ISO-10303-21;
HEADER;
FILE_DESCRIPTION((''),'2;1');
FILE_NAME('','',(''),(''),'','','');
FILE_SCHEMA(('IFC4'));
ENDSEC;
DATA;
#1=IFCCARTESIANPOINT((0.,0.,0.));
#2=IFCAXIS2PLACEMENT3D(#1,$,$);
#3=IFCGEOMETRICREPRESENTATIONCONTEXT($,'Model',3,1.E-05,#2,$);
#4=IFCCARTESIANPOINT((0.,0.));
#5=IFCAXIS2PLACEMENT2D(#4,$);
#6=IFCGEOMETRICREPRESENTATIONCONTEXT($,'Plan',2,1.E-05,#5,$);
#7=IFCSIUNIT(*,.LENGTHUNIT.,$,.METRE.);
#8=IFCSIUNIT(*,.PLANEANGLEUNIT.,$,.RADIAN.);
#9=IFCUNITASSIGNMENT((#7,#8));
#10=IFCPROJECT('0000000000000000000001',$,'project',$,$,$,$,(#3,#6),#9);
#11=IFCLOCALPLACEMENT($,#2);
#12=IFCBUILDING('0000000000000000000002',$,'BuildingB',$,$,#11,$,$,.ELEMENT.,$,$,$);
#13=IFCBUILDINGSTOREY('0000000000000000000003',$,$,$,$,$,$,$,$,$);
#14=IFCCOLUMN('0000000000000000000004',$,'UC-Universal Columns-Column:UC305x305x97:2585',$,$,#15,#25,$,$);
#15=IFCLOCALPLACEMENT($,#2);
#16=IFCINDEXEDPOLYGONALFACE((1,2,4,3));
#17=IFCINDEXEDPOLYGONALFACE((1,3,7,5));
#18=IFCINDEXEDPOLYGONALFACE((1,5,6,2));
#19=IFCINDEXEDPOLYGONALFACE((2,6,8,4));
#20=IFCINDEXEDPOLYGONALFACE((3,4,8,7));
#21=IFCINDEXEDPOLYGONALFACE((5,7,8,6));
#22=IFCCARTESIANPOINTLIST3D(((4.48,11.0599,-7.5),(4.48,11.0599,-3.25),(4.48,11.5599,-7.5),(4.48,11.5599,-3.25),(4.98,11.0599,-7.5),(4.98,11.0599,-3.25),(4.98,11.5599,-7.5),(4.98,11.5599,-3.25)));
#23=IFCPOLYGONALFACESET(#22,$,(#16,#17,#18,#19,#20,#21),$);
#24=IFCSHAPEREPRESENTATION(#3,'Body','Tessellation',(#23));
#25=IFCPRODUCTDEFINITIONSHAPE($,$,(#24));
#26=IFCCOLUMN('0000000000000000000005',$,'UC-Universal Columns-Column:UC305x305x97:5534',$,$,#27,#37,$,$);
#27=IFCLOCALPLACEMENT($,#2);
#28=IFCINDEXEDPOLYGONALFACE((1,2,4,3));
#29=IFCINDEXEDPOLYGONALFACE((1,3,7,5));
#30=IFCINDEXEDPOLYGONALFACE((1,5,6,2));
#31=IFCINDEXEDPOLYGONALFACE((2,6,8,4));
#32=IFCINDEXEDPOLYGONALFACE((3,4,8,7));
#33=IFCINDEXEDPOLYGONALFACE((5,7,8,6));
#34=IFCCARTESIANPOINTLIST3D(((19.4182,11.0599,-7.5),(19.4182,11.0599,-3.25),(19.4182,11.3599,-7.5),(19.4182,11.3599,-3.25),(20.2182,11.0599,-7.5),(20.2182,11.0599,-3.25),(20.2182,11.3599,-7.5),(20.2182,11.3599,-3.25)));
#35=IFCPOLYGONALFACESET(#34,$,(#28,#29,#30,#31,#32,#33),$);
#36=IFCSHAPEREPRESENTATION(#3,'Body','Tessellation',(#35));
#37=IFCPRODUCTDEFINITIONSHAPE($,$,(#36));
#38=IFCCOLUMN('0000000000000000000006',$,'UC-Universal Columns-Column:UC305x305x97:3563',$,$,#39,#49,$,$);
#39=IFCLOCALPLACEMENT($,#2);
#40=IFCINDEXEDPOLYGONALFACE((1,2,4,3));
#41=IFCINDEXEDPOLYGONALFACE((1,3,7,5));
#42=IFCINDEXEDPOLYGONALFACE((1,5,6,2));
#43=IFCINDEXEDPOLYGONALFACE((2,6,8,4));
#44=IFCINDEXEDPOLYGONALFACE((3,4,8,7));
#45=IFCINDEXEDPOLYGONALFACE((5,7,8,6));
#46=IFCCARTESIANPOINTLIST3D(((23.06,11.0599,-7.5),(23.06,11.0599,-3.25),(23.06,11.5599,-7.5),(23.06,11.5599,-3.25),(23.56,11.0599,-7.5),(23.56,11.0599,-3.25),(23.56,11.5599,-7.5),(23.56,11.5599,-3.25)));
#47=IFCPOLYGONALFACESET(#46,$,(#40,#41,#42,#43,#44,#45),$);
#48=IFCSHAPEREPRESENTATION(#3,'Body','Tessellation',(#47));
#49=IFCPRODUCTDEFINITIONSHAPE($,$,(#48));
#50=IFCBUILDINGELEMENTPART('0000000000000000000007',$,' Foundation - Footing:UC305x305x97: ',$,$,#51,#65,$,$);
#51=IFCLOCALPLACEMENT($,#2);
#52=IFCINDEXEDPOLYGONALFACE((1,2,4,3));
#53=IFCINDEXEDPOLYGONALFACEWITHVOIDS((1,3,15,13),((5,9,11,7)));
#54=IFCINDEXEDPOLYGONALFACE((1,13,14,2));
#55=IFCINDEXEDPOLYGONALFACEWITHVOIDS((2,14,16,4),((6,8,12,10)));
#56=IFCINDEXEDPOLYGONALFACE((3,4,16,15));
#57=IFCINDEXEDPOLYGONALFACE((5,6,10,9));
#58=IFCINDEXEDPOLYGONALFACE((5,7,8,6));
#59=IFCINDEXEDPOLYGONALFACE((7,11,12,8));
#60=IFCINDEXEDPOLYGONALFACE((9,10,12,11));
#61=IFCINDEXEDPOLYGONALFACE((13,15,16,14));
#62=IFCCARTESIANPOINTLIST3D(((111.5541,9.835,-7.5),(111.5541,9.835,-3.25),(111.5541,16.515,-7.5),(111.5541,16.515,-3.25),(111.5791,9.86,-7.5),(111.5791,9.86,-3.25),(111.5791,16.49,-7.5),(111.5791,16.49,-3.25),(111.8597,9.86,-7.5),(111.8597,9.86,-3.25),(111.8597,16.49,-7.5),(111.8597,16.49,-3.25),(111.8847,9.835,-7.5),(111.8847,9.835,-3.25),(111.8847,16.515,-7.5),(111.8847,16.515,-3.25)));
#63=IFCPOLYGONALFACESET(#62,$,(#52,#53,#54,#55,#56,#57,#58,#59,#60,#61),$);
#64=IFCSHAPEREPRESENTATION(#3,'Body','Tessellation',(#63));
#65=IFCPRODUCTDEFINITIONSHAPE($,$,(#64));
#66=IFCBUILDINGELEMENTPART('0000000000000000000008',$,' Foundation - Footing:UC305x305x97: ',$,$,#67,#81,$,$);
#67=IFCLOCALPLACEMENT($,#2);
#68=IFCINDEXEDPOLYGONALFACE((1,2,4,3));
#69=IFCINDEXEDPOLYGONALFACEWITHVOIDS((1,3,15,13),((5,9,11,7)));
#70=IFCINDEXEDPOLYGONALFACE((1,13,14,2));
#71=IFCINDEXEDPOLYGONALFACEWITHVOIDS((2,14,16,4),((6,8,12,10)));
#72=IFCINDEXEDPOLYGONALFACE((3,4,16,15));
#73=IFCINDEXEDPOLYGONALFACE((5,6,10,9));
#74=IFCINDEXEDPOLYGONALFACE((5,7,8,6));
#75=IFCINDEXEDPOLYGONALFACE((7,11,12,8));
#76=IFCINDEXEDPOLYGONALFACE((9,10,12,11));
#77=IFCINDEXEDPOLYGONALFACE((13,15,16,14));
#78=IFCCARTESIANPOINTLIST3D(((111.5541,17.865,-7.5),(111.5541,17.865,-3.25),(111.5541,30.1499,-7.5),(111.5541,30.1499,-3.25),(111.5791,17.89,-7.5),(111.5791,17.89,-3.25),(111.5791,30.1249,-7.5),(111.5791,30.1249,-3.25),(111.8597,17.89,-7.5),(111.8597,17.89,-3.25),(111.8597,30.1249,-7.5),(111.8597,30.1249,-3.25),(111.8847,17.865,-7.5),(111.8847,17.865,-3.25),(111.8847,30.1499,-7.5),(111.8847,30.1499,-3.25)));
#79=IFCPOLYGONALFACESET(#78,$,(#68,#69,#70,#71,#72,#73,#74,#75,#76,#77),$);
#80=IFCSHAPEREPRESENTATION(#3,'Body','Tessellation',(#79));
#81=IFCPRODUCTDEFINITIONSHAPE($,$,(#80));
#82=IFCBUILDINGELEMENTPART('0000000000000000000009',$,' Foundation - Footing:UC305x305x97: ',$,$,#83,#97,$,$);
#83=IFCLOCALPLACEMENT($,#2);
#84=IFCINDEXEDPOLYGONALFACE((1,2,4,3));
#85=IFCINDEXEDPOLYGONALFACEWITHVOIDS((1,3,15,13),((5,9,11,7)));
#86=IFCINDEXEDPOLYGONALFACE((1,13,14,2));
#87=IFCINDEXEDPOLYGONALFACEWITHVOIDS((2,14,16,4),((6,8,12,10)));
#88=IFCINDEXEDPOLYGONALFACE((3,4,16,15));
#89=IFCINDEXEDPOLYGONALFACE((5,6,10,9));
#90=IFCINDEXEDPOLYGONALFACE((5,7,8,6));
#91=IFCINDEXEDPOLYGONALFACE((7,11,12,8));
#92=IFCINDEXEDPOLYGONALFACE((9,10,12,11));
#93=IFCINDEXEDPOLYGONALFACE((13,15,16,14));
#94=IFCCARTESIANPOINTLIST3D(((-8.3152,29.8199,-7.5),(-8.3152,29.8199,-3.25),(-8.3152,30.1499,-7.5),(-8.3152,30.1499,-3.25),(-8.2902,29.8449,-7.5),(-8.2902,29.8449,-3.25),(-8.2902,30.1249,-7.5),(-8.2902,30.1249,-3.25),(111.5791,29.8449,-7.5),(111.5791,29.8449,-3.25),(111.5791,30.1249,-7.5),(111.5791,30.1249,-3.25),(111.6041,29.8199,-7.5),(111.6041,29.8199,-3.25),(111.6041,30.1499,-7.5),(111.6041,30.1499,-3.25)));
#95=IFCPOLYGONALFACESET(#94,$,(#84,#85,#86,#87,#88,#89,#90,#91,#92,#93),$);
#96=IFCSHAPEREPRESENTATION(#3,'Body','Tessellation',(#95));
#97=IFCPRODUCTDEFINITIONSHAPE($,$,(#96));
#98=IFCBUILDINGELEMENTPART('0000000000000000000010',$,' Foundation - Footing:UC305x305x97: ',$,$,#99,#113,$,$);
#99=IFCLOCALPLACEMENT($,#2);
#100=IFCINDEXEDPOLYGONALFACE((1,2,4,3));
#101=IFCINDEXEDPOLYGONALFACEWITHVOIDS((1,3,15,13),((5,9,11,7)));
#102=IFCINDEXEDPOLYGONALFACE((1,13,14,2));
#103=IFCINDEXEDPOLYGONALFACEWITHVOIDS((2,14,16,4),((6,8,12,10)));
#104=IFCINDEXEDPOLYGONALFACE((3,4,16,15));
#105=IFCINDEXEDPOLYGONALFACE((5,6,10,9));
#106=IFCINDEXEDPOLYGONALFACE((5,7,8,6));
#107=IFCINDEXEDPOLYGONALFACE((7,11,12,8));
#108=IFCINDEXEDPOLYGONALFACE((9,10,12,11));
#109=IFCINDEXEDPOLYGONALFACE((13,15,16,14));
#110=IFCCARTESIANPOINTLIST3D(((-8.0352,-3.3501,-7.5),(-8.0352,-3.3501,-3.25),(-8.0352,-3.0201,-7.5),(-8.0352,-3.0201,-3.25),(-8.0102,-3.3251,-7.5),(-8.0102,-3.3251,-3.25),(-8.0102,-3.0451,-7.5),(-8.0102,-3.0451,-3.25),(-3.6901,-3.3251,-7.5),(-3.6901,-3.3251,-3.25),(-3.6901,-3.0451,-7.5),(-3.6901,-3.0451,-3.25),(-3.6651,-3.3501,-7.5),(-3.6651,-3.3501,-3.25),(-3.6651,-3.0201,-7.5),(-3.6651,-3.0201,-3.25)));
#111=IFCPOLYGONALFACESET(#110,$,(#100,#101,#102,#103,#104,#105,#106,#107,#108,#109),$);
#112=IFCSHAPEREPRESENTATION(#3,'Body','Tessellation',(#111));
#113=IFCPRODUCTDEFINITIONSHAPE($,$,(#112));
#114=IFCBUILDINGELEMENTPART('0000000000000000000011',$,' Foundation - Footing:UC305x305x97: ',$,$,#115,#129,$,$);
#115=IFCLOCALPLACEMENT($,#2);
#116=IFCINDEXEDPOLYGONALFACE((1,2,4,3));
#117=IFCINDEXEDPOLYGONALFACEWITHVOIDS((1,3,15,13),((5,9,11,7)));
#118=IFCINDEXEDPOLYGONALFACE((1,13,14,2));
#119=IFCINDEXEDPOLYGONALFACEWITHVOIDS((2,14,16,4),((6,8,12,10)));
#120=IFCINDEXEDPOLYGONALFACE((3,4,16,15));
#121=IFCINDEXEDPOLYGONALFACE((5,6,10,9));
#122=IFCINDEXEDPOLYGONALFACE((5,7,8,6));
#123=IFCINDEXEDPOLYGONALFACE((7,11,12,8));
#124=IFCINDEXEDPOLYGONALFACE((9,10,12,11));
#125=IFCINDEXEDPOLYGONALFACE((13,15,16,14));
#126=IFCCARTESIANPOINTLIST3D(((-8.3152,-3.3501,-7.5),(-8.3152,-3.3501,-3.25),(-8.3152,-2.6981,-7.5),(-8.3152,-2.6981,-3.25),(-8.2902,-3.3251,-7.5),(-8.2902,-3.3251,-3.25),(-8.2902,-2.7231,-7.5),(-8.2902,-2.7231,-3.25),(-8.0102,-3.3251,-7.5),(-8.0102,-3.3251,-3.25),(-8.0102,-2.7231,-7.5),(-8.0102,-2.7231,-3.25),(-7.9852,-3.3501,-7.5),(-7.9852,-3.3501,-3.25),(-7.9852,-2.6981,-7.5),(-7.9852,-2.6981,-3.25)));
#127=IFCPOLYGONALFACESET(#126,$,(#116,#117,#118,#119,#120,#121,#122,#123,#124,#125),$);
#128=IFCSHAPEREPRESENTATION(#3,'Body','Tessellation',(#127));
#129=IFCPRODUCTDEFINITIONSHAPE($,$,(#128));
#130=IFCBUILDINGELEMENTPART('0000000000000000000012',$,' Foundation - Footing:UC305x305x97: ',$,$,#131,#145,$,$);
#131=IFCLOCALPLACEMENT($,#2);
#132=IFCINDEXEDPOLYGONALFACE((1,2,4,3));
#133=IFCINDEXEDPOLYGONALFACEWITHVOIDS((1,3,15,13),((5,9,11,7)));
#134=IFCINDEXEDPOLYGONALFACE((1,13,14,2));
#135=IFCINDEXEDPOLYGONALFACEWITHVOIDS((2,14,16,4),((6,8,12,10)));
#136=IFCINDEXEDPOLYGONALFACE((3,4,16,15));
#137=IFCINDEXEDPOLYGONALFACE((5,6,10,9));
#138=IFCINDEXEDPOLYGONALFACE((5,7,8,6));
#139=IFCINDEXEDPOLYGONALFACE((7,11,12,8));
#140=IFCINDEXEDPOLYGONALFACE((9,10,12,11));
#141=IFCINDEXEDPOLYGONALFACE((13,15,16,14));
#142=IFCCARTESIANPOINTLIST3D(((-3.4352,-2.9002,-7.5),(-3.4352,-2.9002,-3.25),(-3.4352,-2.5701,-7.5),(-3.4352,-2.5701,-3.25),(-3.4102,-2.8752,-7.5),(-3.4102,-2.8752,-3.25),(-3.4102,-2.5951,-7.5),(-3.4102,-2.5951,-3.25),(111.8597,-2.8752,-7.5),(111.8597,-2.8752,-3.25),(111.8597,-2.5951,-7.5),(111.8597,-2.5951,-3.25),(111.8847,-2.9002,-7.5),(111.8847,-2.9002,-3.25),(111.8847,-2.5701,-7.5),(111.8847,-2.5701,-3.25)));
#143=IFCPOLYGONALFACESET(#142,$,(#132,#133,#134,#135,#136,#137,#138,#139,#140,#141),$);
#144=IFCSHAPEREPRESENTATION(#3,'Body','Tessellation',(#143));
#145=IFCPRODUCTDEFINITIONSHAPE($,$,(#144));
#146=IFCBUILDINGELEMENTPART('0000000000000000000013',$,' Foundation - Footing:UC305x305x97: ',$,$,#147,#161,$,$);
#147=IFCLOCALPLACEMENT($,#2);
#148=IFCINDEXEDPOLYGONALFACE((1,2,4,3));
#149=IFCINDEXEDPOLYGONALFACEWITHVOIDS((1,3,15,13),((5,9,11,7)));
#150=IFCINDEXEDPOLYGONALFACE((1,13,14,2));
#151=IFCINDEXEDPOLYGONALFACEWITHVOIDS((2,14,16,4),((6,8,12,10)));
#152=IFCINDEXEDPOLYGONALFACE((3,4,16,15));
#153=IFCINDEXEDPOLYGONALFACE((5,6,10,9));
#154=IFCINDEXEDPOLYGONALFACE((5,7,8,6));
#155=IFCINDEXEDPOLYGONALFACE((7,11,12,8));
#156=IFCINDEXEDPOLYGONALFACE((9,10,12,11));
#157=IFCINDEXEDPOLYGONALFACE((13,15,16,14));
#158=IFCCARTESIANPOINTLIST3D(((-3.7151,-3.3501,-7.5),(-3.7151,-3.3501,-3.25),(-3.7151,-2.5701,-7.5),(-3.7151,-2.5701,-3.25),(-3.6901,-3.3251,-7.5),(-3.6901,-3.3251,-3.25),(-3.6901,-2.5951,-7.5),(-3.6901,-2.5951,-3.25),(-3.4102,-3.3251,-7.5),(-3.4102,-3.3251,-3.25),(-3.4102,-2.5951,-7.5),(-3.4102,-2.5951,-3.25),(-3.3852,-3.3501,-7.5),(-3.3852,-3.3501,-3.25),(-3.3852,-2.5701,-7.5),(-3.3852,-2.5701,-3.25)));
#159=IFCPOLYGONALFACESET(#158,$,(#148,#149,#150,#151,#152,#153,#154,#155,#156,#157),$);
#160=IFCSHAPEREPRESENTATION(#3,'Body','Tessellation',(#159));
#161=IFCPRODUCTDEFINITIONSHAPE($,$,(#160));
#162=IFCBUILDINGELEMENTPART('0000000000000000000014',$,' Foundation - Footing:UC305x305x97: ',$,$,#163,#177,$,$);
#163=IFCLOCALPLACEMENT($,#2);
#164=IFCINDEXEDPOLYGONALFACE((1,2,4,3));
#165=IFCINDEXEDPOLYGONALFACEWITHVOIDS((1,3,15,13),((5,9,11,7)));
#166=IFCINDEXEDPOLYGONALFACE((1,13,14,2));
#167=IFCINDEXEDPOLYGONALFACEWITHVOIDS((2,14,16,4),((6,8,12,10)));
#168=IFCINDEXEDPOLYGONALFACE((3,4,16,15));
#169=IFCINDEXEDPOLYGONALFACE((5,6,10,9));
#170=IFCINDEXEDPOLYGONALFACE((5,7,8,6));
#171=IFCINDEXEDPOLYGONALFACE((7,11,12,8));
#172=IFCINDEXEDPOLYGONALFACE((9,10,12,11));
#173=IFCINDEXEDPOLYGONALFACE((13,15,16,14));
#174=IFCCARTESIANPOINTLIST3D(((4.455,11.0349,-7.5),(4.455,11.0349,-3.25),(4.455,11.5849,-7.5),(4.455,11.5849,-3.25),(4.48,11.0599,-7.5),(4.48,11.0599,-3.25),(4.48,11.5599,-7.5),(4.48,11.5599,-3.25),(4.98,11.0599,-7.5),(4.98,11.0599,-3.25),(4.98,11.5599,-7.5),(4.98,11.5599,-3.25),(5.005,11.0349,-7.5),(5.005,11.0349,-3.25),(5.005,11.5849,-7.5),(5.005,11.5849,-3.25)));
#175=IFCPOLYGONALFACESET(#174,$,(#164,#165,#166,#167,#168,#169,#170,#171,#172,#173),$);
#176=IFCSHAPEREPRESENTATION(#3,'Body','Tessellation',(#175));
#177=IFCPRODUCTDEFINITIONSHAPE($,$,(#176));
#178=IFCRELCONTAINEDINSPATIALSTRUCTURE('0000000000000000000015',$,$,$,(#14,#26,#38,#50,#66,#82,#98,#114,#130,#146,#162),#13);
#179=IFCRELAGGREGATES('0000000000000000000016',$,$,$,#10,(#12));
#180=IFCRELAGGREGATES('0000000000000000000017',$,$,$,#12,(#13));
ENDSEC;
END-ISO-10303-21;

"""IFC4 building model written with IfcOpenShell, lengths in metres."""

from ifc_helpers import new_model, si_unit, origin, origin_2d, place, context, project, spatial, polyline, outline, extrude, element, save


model = new_model("IFC4")

# Units and contexts
model_context = context("Model", 3, precision=1e-05, world=origin())
plan_context = context("Plan", 2, precision=1e-05, world=origin_2d())
ifc_project = project(units=[si_unit("LENGTHUNIT", "METRE"), si_unit("PLANEANGLEUNIT", "RADIAN")], contexts=[model_context, plan_context])

# Building, storey
building_placement = place(None, origin())
building = spatial("IfcBuilding", under=ifc_project, at=building_placement, Name="BuildingB", CompositionType="ELEMENT")
storey = spatial("IfcBuildingStorey", under=building)

# Columns
element("IfcColumn", 1, inside=storey, Name="UC-Universal Columns-Column:UC305x305x97:2585", context=model_context, shape_type="SweptSolid", body=[
    extrude(outline(polyline([(4.98, 11.0599, -7.5), (4.48, 11.0599, -7.5), (4.48, 11.5599, -7.5), (4.98, 11.5599, -7.5), (4.98, 11.0599, -7.5)])), None, (0.0, 0.0, 1.0), 4.25),
])
element("IfcColumn", 2, inside=storey, Name="UC-Universal Columns-Column:UC305x305x97:5534", context=model_context, shape_type="SweptSolid", body=[
    extrude(outline(polyline([(19.4182, 11.0599, -7.5), (20.2182, 11.0599, -7.5), (20.2182, 11.3599, -7.5), (19.4182, 11.3599, -7.5), (19.4182, 11.0599, -7.5)])), None, (0.0, 0.0, 1.0), 4.25),
])
element("IfcColumn", 3, inside=storey, Name="UC-Universal Columns-Column:UC305x305x97:3563", context=model_context, shape_type="SweptSolid", body=[
    extrude(outline(polyline([(23.06, 11.0599, -7.5), (23.56, 11.0599, -7.5), (23.56, 11.5599, -7.5), (23.06, 11.5599, -7.5), (23.06, 11.0599, -7.5)])), None, (0.0, 0.0, 1.0), 4.25),
])

# Building element parts, openings
building_element_part_1 = element("IfcBuildingElementPart", 4, inside=storey, Name=" Foundation - Footing:UC305x305x97: ", context=model_context, shape_type="SweptSolid", body=[
    extrude(outline(polyline([(111.8847, 9.835, -7.5), (111.5541, 9.835, -7.5), (111.5541, 16.515, -7.5), (111.8847, 16.515, -7.5), (111.8847, 9.835, -7.5)])), None, (0.0, 0.0, 1.0), 4.25),
])
element("IfcOpeningElement", 5, inside=storey, cuts=building_element_part_1, context=model_context, shape_type="SweptSolid", body=[
    extrude(outline(polyline([(111.8597, 9.86, -7.5), (111.5791, 9.86, -7.5), (111.5791, 16.49, -7.5), (111.8597, 16.49, -7.5), (111.8597, 9.86, -7.5)])), None, (0.0, 0.0, 1.0), 4.25),
])
building_element_part_2 = element("IfcBuildingElementPart", 6, inside=storey, Name=" Foundation - Footing:UC305x305x97: ", context=model_context, shape_type="SweptSolid", body=[
    extrude(outline(polyline([(111.8847, 30.1499, -7.5), (111.8847, 17.865, -7.5), (111.5541, 17.865, -7.5), (111.5541, 30.1499, -7.5), (111.8847, 30.1499, -7.5)])), None, (0.0, 0.0, 1.0), 4.25),
])
element("IfcOpeningElement", 7, inside=storey, cuts=building_element_part_2, context=model_context, shape_type="SweptSolid", body=[
    extrude(outline(polyline([(111.8597, 30.1249, -7.5), (111.8597, 17.89, -7.5), (111.5791, 17.89, -7.5), (111.5791, 30.1249, -7.5), (111.8597, 30.1249, -7.5)])), None, (0.0, 0.0, 1.0), 4.25),
])
building_element_part_3 = element("IfcBuildingElementPart", 8, inside=storey, Name=" Foundation - Footing:UC305x305x97: ", context=model_context, shape_type="SweptSolid", body=[
    extrude(outline(polyline([(-8.3152, 30.1499, -7.5), (111.6041, 30.1499, -7.5), (111.6041, 29.8199, -7.5), (-8.3152, 29.8199, -7.5), (-8.3152, 30.1499, -7.5)])), None, (0.0, 0.0, 1.0), 4.25),
])
element("IfcOpeningElement", 9, inside=storey, cuts=building_element_part_3, context=model_context, shape_type="SweptSolid", body=[
    extrude(outline(polyline([(-8.2902, 30.1249, -7.5), (111.5791, 30.1249, -7.5), (111.5791, 29.8449, -7.5), (-8.2902, 29.8449, -7.5), (-8.2902, 30.1249, -7.5)])), None, (0.0, 0.0, 1.0), 4.25),
])
building_element_part_4 = element("IfcBuildingElementPart", 10, inside=storey, Name=" Foundation - Footing:UC305x305x97: ", context=model_context, shape_type="SweptSolid", body=[
    extrude(outline(polyline([(-3.6651, -3.3501, -7.5), (-8.0352, -3.3501, -7.5), (-8.0352, -3.0201, -7.5), (-3.6651, -3.0201, -7.5), (-3.6651, -3.3501, -7.5)])), None, (0.0, 0.0, 1.0), 4.25),
])
element("IfcOpeningElement", 11, inside=storey, cuts=building_element_part_4, context=model_context, shape_type="SweptSolid", body=[
    extrude(outline(polyline([(-3.6901, -3.3251, -7.5), (-8.0102, -3.3251, -7.5), (-8.0102, -3.0451, -7.5), (-3.6901, -3.0451, -7.5), (-3.6901, -3.3251, -7.5)])), None, (0.0, 0.0, 1.0), 4.25),
])
building_element_part_5 = element("IfcBuildingElementPart", 12, inside=storey, Name=" Foundation - Footing:UC305x305x97: ", context=model_context, shape_type="SweptSolid", body=[
    extrude(outline(polyline([(-7.9852, -3.3501, -7.5), (-8.3152, -3.3501, -7.5), (-8.3152, -2.6981, -7.5), (-7.9852, -2.6981, -7.5), (-7.9852, -3.3501, -7.5)])), None, (0.0, 0.0, 1.0), 4.25),
])
element("IfcOpeningElement", 13, inside=storey, cuts=building_element_part_5, context=model_context, shape_type="SweptSolid", body=[
    extrude(outline(polyline([(-8.0102, -3.3251, -7.5), (-8.2902, -3.3251, -7.5), (-8.2902, -2.7231, -7.5), (-8.0102, -2.7231, -7.5), (-8.0102, -3.3251, -7.5)])), None, (0.0, 0.0, 1.0), 4.25),
])
building_element_part_6 = element("IfcBuildingElementPart", 14, inside=storey, Name=" Foundation - Footing:UC305x305x97: ", context=model_context, shape_type="SweptSolid", body=[
    extrude(outline(polyline([(-3.4352, -2.5701, -7.5), (111.8847, -2.5701, -7.5), (111.8847, -2.9002, -7.5), (-3.4352, -2.9002, -7.5), (-3.4352, -2.5701, -7.5)])), None, (0.0, 0.0, 1.0), 4.25),
])
element("IfcOpeningElement", 15, inside=storey, cuts=building_element_part_6, context=model_context, shape_type="SweptSolid", body=[
    extrude(outline(polyline([(-3.4102, -2.5951, -7.5), (111.8597, -2.5951, -7.5), (111.8597, -2.8752, -7.5), (-3.4102, -2.8752, -7.5), (-3.4102, -2.5951, -7.5)])), None, (0.0, 0.0, 1.0), 4.25),
])
building_element_part_7 = element("IfcBuildingElementPart", 16, inside=storey, Name=" Foundation - Footing:UC305x305x97: ", context=model_context, shape_type="SweptSolid", body=[
    extrude(outline(polyline([(-3.3852, -2.5701, -7.5), (-3.3852, -3.3501, -7.5), (-3.7151, -3.3501, -7.5), (-3.7151, -2.5701, -7.5), (-3.3852, -2.5701, -7.5)])), None, (0.0, 0.0, 1.0), 4.25),
])
element("IfcOpeningElement", 17, inside=storey, cuts=building_element_part_7, context=model_context, shape_type="SweptSolid", body=[
    extrude(outline(polyline([(-3.4102, -2.5951, -7.5), (-3.4102, -3.3251, -7.5), (-3.6901, -3.3251, -7.5), (-3.6901, -2.5951, -7.5), (-3.4102, -2.5951, -7.5)])), None, (0.0, 0.0, 1.0), 4.25),
])
building_element_part_8 = element("IfcBuildingElementPart", 18, inside=storey, Name=" Foundation - Footing:UC305x305x97: ", context=model_context, shape_type="SweptSolid", body=[
    extrude(outline(polyline([(5.005, 11.0349, -7.5), (4.455, 11.0349, -7.5), (4.455, 11.5849, -7.5), (5.005, 11.5849, -7.5), (5.005, 11.0349, -7.5)])), None, (0.0, 0.0, 1.0), 4.25),
])
element("IfcOpeningElement", 19, inside=storey, cuts=building_element_part_8, context=model_context, shape_type="SweptSolid", body=[
    extrude(outline(polyline([(4.98, 11.0599, -7.5), (4.48, 11.0599, -7.5), (4.48, 11.5599, -7.5), (4.98, 11.5599, -7.5), (4.98, 11.0599, -7.5)])), None, (0.0, 0.0, 1.0), 4.25),
])

save(model, "model.ifc")
